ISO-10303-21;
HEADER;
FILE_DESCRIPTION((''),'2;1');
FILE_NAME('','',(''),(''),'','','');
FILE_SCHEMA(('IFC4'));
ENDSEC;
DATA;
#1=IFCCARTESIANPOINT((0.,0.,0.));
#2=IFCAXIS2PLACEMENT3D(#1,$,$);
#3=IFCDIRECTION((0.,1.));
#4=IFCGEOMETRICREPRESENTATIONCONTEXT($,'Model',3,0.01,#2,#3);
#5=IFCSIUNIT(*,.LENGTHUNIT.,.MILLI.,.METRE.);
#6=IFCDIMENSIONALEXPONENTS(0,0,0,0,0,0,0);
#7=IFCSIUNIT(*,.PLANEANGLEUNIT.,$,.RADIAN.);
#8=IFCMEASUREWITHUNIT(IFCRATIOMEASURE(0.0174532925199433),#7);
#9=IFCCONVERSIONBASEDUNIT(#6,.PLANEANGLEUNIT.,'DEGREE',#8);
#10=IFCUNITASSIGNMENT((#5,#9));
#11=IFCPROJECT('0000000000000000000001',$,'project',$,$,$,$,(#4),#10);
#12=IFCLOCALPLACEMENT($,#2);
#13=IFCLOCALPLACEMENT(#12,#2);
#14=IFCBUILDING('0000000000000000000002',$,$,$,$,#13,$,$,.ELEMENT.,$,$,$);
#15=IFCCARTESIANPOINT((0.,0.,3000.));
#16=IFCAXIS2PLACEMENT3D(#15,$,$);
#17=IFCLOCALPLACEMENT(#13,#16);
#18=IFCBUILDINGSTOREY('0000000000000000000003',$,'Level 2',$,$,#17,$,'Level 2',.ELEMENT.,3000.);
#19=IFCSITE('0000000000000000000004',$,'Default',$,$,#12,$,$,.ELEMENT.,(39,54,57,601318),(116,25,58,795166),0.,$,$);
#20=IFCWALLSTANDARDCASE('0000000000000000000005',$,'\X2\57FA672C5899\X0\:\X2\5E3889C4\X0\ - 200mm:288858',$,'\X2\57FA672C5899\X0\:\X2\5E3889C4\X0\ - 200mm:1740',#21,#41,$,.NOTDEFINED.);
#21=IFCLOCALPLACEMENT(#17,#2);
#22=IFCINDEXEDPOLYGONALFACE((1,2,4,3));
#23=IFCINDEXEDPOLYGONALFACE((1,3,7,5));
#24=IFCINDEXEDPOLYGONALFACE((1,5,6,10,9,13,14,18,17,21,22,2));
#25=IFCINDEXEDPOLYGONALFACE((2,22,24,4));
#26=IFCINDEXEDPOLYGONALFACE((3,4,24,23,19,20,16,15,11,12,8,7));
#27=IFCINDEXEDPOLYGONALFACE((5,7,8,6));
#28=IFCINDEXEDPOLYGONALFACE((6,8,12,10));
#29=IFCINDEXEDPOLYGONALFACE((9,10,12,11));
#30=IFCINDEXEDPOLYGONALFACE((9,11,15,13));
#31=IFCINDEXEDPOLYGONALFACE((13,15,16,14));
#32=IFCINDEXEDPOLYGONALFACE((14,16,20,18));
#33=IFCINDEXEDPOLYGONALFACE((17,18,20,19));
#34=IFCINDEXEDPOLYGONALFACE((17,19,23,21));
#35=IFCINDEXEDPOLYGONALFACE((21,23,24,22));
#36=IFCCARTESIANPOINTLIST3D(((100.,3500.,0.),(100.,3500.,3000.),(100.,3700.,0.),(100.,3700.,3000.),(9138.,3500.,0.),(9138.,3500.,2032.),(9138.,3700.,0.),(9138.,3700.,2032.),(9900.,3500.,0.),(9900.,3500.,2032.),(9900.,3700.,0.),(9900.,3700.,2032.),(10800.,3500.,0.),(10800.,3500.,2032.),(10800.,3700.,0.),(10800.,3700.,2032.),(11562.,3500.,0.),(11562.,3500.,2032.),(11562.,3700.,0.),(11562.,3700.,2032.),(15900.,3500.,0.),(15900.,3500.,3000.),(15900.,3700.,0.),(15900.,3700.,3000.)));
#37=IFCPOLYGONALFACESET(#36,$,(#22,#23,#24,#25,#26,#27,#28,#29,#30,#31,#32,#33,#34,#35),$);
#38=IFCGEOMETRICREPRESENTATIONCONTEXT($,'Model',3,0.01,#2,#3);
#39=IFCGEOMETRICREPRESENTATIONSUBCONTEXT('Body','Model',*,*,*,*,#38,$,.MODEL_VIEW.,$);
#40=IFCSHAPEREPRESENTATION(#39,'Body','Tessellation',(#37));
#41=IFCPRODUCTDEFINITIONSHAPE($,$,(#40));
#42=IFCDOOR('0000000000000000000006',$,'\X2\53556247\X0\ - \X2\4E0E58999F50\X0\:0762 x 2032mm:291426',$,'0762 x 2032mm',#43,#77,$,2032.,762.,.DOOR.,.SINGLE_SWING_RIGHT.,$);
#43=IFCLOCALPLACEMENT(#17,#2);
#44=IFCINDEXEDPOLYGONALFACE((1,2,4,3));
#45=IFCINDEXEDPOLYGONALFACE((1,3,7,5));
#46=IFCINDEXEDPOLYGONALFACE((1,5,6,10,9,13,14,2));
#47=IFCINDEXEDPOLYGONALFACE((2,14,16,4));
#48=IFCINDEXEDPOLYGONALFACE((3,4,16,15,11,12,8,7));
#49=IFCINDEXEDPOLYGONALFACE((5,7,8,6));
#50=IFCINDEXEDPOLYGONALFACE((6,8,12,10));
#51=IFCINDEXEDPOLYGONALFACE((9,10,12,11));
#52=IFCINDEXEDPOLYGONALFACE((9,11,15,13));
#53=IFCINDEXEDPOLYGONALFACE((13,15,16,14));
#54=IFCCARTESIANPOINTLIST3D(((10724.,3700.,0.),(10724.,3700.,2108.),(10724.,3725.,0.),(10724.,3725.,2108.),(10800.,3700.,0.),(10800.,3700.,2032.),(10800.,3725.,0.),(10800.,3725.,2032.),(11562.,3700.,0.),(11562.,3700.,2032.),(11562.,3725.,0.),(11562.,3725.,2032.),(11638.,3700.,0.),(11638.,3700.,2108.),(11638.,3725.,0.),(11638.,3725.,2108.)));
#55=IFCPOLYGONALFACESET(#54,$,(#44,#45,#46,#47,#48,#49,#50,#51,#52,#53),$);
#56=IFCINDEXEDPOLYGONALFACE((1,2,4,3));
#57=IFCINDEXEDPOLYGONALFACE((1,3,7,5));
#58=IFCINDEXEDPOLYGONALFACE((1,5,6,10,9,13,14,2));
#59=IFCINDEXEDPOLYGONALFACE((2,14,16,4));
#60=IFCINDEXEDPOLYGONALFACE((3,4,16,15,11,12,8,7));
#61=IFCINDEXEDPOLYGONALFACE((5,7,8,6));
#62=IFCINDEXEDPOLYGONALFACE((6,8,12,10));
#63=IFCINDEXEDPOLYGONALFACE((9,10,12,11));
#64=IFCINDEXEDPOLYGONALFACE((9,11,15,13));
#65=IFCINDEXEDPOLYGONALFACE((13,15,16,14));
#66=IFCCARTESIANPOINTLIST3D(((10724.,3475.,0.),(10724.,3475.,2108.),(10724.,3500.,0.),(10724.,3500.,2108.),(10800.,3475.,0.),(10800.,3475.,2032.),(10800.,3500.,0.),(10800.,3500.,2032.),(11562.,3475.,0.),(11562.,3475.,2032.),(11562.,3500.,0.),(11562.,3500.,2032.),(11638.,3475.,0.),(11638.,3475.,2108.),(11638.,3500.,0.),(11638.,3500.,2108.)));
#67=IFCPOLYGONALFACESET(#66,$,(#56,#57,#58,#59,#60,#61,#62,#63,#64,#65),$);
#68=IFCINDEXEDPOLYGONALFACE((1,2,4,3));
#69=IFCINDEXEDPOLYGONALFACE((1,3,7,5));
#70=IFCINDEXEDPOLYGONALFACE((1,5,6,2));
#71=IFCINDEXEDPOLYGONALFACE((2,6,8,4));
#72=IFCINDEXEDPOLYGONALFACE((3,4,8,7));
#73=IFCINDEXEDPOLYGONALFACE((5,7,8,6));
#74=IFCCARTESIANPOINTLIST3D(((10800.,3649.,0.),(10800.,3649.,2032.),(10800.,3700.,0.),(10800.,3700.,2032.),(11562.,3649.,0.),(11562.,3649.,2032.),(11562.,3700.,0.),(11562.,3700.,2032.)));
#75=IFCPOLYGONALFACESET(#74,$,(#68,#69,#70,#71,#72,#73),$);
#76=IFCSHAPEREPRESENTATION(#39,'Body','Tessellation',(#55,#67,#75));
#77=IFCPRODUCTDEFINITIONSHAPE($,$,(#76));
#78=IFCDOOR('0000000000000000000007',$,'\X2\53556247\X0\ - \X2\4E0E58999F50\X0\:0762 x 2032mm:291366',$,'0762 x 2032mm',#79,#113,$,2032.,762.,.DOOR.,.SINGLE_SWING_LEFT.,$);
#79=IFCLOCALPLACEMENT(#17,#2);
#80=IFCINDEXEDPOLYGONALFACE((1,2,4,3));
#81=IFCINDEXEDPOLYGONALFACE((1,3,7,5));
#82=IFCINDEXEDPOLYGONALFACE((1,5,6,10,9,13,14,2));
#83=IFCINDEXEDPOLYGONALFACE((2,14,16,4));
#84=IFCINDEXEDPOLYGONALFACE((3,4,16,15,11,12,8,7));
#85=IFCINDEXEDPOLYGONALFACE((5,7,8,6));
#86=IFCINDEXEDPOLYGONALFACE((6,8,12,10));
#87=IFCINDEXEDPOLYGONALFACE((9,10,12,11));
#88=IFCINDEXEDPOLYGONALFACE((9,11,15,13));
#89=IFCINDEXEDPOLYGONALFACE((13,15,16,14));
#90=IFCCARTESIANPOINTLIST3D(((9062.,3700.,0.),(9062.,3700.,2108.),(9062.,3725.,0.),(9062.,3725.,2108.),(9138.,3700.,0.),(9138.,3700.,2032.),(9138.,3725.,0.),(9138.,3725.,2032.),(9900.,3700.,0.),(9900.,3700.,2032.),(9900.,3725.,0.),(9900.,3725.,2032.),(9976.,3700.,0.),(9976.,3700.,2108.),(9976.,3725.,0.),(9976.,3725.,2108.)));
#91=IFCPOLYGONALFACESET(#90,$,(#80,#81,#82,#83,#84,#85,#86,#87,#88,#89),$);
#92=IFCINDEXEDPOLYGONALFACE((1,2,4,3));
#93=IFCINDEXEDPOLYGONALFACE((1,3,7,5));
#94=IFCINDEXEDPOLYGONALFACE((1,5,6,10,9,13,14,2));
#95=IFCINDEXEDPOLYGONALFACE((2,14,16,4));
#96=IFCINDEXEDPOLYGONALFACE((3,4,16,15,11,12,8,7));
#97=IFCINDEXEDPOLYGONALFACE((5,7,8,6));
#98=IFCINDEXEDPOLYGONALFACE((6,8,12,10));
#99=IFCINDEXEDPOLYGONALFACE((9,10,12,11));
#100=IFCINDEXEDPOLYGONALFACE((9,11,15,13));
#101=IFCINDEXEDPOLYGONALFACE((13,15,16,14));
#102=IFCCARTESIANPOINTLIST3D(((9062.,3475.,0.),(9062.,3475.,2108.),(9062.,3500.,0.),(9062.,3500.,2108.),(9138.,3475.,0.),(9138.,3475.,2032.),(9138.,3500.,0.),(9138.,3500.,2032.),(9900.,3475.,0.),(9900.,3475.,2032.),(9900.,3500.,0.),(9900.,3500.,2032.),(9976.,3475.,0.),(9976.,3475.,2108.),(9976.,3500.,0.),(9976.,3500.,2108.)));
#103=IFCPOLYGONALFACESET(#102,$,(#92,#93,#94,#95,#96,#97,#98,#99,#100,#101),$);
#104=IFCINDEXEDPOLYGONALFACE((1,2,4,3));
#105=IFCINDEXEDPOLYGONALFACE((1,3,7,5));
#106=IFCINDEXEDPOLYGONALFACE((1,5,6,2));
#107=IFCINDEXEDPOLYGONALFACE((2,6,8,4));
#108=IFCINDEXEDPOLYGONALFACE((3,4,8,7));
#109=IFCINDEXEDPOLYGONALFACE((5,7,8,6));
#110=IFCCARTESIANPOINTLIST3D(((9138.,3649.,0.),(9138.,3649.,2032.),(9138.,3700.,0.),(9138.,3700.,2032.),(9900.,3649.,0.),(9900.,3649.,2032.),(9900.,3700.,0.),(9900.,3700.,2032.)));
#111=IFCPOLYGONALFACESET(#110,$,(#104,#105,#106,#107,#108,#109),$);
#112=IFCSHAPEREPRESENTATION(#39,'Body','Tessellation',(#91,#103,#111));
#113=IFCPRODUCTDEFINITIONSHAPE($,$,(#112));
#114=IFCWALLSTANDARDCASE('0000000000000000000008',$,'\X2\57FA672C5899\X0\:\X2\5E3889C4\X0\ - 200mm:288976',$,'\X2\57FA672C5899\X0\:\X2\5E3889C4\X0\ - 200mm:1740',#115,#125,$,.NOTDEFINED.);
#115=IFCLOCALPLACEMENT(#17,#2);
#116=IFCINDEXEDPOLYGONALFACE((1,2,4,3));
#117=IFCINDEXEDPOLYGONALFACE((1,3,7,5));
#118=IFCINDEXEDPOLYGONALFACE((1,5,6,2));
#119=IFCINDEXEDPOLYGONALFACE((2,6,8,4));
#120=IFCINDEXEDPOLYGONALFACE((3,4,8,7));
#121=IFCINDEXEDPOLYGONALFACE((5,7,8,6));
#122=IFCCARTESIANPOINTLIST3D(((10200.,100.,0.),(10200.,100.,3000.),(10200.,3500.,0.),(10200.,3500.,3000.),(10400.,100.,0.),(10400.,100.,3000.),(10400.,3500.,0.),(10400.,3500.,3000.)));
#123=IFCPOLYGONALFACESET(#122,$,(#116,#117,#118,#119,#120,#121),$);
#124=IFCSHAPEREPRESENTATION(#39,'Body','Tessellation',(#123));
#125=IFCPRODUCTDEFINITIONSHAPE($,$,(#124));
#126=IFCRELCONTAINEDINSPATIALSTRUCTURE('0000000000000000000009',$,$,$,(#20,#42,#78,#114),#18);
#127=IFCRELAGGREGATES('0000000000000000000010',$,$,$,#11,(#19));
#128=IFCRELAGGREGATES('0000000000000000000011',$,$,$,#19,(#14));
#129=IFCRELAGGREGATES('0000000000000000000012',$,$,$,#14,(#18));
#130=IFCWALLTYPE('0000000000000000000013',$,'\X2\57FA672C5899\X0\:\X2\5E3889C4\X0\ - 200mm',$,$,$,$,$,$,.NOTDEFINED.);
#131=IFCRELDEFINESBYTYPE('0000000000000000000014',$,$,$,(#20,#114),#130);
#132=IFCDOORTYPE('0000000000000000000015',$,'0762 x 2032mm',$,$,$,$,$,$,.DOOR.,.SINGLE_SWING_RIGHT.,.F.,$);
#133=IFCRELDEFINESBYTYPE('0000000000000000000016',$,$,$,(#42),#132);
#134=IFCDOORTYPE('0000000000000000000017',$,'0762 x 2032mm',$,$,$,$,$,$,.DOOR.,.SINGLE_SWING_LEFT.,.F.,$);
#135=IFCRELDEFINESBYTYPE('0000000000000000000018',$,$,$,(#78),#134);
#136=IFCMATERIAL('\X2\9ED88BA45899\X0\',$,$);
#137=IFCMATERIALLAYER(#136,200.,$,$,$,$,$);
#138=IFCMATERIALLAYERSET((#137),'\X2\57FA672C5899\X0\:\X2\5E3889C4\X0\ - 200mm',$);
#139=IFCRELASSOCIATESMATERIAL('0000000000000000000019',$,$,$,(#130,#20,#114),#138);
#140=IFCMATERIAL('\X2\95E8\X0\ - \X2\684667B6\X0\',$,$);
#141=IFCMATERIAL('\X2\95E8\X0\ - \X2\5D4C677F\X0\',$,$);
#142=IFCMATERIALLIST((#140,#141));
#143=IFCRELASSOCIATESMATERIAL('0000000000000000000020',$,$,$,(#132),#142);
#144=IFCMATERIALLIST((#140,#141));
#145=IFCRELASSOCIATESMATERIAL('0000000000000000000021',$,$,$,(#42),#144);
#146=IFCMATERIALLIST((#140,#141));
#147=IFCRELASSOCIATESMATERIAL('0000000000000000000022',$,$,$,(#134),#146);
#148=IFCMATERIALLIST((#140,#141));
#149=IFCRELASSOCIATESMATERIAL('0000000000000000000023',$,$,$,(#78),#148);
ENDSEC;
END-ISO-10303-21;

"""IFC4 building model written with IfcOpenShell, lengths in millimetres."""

from ifc_helpers import new_model, entity, si_unit, converted_unit, direction, frame, frame_2d, origin, origin_2d_with_axis, place, context, subcontext, project, spatial, polyline, rectangle, outline, extrude, source, transform, mapped, material, material_list, layer, layer_set, layer_usage, type_object, type_shapes, element, fill, save


model = new_model("IFC4")

# Units and contexts
model_context_1 = context("Model", 3, precision=0.01, world=origin(), true_north=direction((0.0, 1.0)))
model_context_2 = context("Model", 3, precision=0.01, world=origin(), true_north=direction((0.0, 1.0)))
body_context = subcontext(model_context_2, "Body", "Model", "MODEL_VIEW")
ifc_project = project(units=[si_unit("LENGTHUNIT", "METRE", prefix="MILLI"), converted_unit("PLANEANGLEUNIT", "DEGREE", entity("IfcRatioMeasure", 0.0174532925199433), si_unit("PLANEANGLEUNIT", "RADIAN"), dimensions=[0, 0, 0, 0, 0, 0, 0])], contexts=[model_context_1])

# Site, building, storey
site_placement = place(None, origin())
site = spatial("IfcSite", under=ifc_project, at=site_placement, Name="Default", CompositionType="ELEMENT", RefLatitude=(39, 54, 57, 601318), RefLongitude=(116, 25, 58, 795166), RefElevation=0.0)
building_placement = place(site_placement, origin())
building = spatial("IfcBuilding", under=site, at=building_placement, CompositionType="ELEMENT")
storey_placement = place(building_placement, frame((0.0, 0.0, 3000.0)))
storey = spatial("IfcBuildingStorey", under=building, at=storey_placement, Name="Level 2", LongName="Level 2", CompositionType="ELEMENT", Elevation=3000.0)

# Shared definitions
ifc_material_1 = material(Name="默认墙")
ifc_layer = layer(ifc_material_1, 200.0)
ifc_layer_set = layer_set([ifc_layer], Name="基本墙:常规 - 200mm")
wall_type = type_object("IfcWallType", Name="基本墙:常规 - 200mm", PredefinedType="NOTDEFINED", material=ifc_layer_set)

# Shared definitions
ifc_material_2 = material(Name="门 - 框架")
ifc_material_3 = material(Name="门 - 嵌板")
ifc_material_list_1 = material_list([ifc_material_2, ifc_material_3])
door_type_1 = type_object("IfcDoorType", Name="0762 x 2032mm", OperationType="SINGLE_SWING_RIGHT", ParameterTakesPrecedence=False, PredefinedType="DOOR", material=ifc_material_list_1)
shared_shape_1 = source(origin(), body_context, "Body", "SweptSolid", [
    extrude(outline(polyline([(-457.0, -1073.0), (457.0, -1073.0), (457.0, 1035.0), (381.0, 1035.0), (381.0, -997.0), (-381.0, -997.0), (-381.0, 1035.0), (-457.0, 1035.0), (-457.0, -1073.0)])), frame((381.0, 200.0, 1035.0), z_axis=(0.0, 1.0, 0.0), x_axis=(1.0, 0.0, 0.0)), (0.0, 0.0, 1.0), 25.0),
    extrude(outline(polyline([(-1073.0, -457.0), (1035.0, -457.0), (1035.0, -381.0), (-997.0, -381.0), (-997.0, 381.0), (1035.0, 381.0), (1035.0, 457.0), (-1073.0, 457.0), (-1073.0, -457.0)])), frame((381.0, -25.0, 1035.0), z_axis=(0.0, 1.0, 0.0), x_axis=(0.0, 0.0, -1.0)), (0.0, 0.0, 1.0), 25.0),
    extrude(rectangle(XDim=51.0, YDim=762.0, at=origin_2d_with_axis()), frame((381.0, 174.5, 0.0), z_axis=(0.0, 0.0, 1.0), x_axis=(0.0, 1.0, 0.0)), (0.0, 0.0, 1.0), 2032.0),
])
type_shapes(door_type_1, [shared_shape_1])

# Wall, openings, doors
ifc_layer_usage_1 = layer_usage(ifc_layer_set, "AXIS2", "NEGATIVE", 100.0)
wall_1_placement = place(storey_placement, frame((15900.0, 3600.0, 0.0), z_axis=(0.0, 0.0, 1.0), x_axis=(-1.0, 0.0, 0.0)))
wall_1 = element("IfcWallStandardCase", 1, at=wall_1_placement, inside=storey, type_object=wall_type, material=ifc_layer_usage_1, Name="基本墙:常规 - 200mm:288858", ObjectType="基本墙:常规 - 200mm:1740", PredefinedType="NOTDEFINED", context=body_context, shape_type="SweptSolid", body=[
    extrude(rectangle(XDim=15800.0, YDim=200.0, at=frame_2d((7900.0, 0.0), x_axis=(-1.0, 0.0))), origin(), (0.0, 0.0, 1.0), 3000.0),
])
opening_1_placement = place(wall_1_placement, frame((6762.0, 100.0, 0.0)))
opening_1 = element("IfcOpeningElement", 2, at=opening_1_placement, cuts=wall_1, ObjectType="Opening", PredefinedType="OPENING", context=body_context, shape_type="SweptSolid", body=[
    extrude(rectangle(XDim=762.0, YDim=2032.0, at=frame_2d((1016.0, 381.0), x_axis=(0.0, -1.0))), frame((0.0, 0.0, 0.0), z_axis=(0.0, -1.0, 0.0), x_axis=(0.0, 0.0, 1.0)), (0.0, 0.0, 1.0), 200.0),
])
opening_2_placement = place(wall_1_placement, frame((5100.0, 100.0, 0.0)))
opening_2 = element("IfcOpeningElement", 3, at=opening_2_placement, cuts=wall_1, ObjectType="Opening", PredefinedType="OPENING", context=body_context, shape_type="SweptSolid", body=[
    extrude(rectangle(XDim=762.0, YDim=2032.0, at=frame_2d((1016.0, 381.0), x_axis=(0.0, 1.0))), frame((0.0, 0.0, 0.0), z_axis=(0.0, -1.0, 0.0), x_axis=(0.0, 0.0, 1.0)), (0.0, 0.0, 1.0), 200.0),
])
ifc_material_list_2 = material_list([ifc_material_2, ifc_material_3])
door_1_placement = place(opening_2_placement, frame((0.0, 0.0, 0.0), z_axis=(0.0, 0.0, 1.0), x_axis=(-1.0, 0.0, 0.0)))
door_1 = element("IfcDoor", 4, at=door_1_placement, inside=storey, type_object=door_type_1, material=ifc_material_list_2, Name="单扇 - 与墙齐:0762 x 2032mm:291426", ObjectType="0762 x 2032mm", OperationType="SINGLE_SWING_RIGHT", OverallHeight=2032.0, OverallWidth=762.0, PredefinedType="DOOR", context=body_context, shape_type="MappedRepresentation", body=[
    mapped(shared_shape_1, transform((0.0, 0.0, 0.0), scale=1.0)),
])
fill(opening_2, door_1)
ifc_material_list_3 = material_list([ifc_material_2, ifc_material_3])
ifc_material_list_4 = material_list([ifc_material_2, ifc_material_3])
door_type_2 = type_object("IfcDoorType", Name="0762 x 2032mm", OperationType="SINGLE_SWING_LEFT", ParameterTakesPrecedence=False, PredefinedType="DOOR", material=ifc_material_list_4)
shared_shape_2 = source(origin(), body_context, "Body", "SweptSolid", [
    extrude(outline(polyline([(-457.0, -1073.0), (457.0, -1073.0), (457.0, 1035.0), (381.0, 1035.0), (381.0, -997.0), (-381.0, -997.0), (-381.0, 1035.0), (-457.0, 1035.0), (-457.0, -1073.0)])), frame((381.0, 225.0, 1035.0), z_axis=(0.0, -1.0, 0.0), x_axis=(-1.0, 0.0, 0.0)), (0.0, 0.0, 1.0), 25.0),
    extrude(outline(polyline([(-1073.0, -457.0), (1035.0, -457.0), (1035.0, -381.0), (-997.0, -381.0), (-997.0, 381.0), (1035.0, 381.0), (1035.0, 457.0), (-1073.0, 457.0), (-1073.0, -457.0)])), frame((381.0, 0.0, 1035.0), z_axis=(0.0, -1.0, 0.0), x_axis=(0.0, 0.0, -1.0)), (0.0, 0.0, 1.0), 25.0),
    extrude(rectangle(XDim=762.0, YDim=51.0, at=origin_2d_with_axis()), frame((381.0, 174.5, 0.0)), (0.0, 0.0, 1.0), 2032.0),
])
type_shapes(door_type_2, [shared_shape_2])
door_2_placement = place(opening_1_placement, frame((0.0, 0.0, 0.0), z_axis=(0.0, 0.0, 1.0), x_axis=(-1.0, 0.0, 0.0)))
door_2 = element("IfcDoor", 5, at=door_2_placement, inside=storey, type_object=door_type_2, material=ifc_material_list_3, Name="单扇 - 与墙齐:0762 x 2032mm:291366", ObjectType="0762 x 2032mm", OperationType="SINGLE_SWING_LEFT", OverallHeight=2032.0, OverallWidth=762.0, PredefinedType="DOOR", context=body_context, shape_type="MappedRepresentation", body=[
    mapped(shared_shape_2, transform((0.0, 0.0, 0.0), scale=1.0)),
])
fill(opening_1, door_2)

# Wall
ifc_layer_usage_2 = layer_usage(ifc_layer_set, "AXIS2", "NEGATIVE", 100.0)
wall_2_placement = place(storey_placement, frame((10300.0, 3500.0, 0.0), z_axis=(0.0, 0.0, 1.0), x_axis=(0.0, -1.0, 0.0)))
element("IfcWallStandardCase", 6, at=wall_2_placement, inside=storey, type_object=wall_type, material=ifc_layer_usage_2, Name="基本墙:常规 - 200mm:288976", ObjectType="基本墙:常规 - 200mm:1740", PredefinedType="NOTDEFINED", context=body_context, shape_type="SweptSolid", body=[
    extrude(rectangle(XDim=3400.0, YDim=200.0, at=frame_2d((1700.0, 0.0), x_axis=(-1.0, 0.0))), origin(), (0.0, 0.0, 1.0), 3000.0),
])

save(model, "model.ifc")
